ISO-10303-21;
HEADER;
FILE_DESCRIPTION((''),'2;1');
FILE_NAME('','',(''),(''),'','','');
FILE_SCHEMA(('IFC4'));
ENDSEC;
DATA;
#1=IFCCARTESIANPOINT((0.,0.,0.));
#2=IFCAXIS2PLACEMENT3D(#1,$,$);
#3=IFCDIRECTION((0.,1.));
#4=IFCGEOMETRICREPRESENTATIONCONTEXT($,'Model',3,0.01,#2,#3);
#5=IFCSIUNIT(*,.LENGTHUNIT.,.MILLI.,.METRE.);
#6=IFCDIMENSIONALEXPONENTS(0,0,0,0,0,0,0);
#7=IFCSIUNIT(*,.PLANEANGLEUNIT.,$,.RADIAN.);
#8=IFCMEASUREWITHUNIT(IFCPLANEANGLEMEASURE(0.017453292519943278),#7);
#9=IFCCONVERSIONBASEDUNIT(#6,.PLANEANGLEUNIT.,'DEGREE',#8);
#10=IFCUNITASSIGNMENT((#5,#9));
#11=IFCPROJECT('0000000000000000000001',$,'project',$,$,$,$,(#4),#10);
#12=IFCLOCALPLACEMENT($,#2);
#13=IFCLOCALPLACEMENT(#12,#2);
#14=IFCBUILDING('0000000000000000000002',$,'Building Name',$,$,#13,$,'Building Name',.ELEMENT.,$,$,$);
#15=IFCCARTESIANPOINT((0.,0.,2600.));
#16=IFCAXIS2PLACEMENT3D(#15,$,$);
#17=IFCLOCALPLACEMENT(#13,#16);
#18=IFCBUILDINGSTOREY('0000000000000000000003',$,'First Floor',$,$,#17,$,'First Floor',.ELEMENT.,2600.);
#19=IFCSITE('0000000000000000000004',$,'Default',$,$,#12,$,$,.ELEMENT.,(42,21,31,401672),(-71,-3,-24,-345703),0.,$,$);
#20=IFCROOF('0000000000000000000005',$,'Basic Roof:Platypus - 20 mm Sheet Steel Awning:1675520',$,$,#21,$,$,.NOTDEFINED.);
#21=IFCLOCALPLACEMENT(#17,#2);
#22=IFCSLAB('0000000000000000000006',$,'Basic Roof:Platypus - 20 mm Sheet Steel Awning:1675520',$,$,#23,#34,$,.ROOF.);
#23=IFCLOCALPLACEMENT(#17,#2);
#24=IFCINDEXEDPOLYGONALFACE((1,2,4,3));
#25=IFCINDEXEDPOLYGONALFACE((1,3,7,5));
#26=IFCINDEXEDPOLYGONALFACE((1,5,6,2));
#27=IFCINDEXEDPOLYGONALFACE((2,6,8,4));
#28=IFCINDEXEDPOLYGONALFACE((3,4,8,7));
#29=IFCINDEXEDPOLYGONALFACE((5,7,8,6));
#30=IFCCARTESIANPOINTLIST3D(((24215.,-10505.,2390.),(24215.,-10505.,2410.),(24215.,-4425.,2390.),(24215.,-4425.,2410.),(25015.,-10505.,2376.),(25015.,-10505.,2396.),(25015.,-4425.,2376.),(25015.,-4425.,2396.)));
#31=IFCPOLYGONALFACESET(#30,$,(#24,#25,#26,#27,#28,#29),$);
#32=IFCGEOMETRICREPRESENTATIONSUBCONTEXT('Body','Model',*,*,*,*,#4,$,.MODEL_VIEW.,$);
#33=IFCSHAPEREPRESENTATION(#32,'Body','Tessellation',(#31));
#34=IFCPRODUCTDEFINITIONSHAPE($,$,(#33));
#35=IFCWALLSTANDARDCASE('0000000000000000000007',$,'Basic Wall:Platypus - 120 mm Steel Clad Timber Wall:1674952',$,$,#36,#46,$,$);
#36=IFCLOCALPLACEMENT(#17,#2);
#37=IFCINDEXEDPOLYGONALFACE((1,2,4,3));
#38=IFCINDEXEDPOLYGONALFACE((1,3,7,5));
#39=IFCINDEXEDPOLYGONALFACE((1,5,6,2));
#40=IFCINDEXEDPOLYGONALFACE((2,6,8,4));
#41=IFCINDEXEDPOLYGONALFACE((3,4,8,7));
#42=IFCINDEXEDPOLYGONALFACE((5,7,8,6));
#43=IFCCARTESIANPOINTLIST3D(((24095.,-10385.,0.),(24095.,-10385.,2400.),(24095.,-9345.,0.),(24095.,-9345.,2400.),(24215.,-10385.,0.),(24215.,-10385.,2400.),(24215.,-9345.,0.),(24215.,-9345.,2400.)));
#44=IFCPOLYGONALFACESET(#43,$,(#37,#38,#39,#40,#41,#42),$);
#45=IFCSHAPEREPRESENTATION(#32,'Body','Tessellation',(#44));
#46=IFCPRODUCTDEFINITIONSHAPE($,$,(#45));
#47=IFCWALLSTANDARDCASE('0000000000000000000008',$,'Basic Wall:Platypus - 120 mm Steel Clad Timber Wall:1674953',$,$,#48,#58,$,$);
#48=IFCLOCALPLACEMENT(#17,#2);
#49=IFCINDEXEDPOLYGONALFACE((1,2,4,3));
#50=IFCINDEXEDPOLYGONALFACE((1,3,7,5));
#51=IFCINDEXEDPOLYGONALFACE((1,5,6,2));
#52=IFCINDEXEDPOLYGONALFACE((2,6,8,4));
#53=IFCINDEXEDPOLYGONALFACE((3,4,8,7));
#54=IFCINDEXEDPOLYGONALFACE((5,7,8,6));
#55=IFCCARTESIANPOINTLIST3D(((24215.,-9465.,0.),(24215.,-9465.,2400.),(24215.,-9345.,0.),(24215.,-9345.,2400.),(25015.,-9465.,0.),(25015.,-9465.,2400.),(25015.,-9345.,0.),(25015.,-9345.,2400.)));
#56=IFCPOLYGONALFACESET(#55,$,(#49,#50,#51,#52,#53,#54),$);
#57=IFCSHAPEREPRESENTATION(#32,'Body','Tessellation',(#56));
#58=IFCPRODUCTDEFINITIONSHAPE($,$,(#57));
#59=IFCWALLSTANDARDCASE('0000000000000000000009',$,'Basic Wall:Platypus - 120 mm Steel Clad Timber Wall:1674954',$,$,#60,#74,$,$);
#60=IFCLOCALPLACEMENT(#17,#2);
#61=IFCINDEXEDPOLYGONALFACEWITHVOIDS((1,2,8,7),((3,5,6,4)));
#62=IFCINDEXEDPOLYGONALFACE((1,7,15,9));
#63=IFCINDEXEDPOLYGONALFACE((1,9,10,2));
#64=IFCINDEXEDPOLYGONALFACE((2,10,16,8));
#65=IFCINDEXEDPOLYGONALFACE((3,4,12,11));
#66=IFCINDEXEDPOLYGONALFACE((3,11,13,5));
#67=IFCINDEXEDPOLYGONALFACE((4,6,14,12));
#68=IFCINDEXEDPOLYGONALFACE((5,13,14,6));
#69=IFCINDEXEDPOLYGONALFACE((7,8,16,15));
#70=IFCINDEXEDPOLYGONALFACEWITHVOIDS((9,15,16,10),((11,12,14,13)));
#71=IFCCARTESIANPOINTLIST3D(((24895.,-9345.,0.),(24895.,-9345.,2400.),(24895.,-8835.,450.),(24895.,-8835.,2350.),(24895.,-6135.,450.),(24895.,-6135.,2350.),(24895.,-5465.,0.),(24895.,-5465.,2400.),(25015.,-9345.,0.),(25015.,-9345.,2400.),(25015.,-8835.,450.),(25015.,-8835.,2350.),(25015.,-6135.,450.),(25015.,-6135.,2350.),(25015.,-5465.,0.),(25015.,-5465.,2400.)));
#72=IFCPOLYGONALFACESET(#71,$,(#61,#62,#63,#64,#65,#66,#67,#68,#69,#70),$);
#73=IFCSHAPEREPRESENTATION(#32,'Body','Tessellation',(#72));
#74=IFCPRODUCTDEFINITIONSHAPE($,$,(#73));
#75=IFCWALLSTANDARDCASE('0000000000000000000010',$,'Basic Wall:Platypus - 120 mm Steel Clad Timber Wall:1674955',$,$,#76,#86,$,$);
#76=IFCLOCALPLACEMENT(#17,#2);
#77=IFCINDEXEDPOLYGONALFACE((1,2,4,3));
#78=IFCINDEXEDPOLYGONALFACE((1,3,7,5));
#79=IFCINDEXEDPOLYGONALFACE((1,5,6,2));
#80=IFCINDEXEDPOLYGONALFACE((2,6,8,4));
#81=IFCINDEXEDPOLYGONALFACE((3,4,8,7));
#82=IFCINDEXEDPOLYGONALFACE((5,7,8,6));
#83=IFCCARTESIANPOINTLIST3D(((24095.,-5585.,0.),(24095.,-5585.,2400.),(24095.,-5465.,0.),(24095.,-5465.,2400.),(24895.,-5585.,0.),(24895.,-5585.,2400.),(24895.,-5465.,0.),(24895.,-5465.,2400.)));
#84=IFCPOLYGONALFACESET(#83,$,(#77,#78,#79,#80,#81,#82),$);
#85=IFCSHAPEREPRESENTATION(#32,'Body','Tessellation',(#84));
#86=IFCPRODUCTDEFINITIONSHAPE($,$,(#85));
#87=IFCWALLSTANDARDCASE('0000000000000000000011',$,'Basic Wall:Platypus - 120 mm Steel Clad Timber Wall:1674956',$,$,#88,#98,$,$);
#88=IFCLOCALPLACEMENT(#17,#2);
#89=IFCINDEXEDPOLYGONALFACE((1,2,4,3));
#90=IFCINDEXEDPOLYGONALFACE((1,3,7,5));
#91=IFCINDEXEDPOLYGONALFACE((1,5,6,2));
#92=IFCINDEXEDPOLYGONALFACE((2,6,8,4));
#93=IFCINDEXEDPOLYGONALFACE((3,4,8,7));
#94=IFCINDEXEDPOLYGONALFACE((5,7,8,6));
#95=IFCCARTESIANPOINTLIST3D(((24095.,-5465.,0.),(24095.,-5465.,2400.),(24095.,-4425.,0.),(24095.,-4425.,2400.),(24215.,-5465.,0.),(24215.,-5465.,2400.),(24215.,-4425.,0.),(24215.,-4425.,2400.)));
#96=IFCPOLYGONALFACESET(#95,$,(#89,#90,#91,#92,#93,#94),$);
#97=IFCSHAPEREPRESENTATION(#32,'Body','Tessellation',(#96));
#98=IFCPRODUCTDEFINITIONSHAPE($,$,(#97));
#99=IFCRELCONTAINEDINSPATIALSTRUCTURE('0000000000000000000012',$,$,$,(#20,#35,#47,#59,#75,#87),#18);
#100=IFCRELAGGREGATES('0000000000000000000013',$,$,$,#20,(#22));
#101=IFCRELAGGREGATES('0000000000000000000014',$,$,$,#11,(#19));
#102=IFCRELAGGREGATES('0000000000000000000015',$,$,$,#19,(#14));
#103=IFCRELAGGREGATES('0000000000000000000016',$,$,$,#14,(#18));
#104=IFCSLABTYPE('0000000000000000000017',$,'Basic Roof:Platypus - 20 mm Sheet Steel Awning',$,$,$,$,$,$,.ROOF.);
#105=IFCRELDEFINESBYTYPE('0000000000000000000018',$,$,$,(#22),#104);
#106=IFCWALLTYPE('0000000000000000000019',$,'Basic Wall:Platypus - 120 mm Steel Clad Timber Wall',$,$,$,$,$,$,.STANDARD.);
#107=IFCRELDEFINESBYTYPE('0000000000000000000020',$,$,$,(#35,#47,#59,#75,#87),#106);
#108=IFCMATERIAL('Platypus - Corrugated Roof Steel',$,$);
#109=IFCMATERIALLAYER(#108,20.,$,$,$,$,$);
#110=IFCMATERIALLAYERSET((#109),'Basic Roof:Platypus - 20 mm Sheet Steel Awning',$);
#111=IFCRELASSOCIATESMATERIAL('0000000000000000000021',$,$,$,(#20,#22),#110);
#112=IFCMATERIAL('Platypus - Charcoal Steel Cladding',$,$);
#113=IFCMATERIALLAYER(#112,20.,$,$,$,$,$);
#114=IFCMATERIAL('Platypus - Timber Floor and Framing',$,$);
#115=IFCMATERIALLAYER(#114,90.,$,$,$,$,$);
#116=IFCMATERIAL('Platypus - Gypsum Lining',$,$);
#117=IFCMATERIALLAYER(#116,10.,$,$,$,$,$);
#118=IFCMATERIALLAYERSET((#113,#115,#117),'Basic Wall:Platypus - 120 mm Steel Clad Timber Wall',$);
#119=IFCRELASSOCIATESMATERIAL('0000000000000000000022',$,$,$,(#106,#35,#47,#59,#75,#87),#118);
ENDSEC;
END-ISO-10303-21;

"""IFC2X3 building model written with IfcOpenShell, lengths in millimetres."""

from ifc_helpers import new_model, entity, si_unit, converted_unit, direction, frame, frame_2d, origin, place, context, subcontext, project, spatial, rectangle, extrude, material, layer, layer_set, layer_usage, type_object, element, aggregate, save


model = new_model("IFC2X3")

# Units and contexts
model_context = context("Model", 3, precision=0.01, world=origin(), true_north=direction((0.0, 1.0)))
body_context = subcontext(model_context, "Body", "Model", "MODEL_VIEW")
ifc_project = project(units=[si_unit("LENGTHUNIT", "METRE", prefix="MILLI"), converted_unit("PLANEANGLEUNIT", "DEGREE", entity("IfcPlaneAngleMeasure", 0.017453292519943278), si_unit("PLANEANGLEUNIT", "RADIAN"), dimensions=[0, 0, 0, 0, 0, 0, 0])], contexts=[model_context])

# Site, building, storey
site_placement = place(None, origin())
site = spatial("IfcSite", under=ifc_project, at=site_placement, Name="Default", CompositionType="ELEMENT", RefLatitude=(42, 21, 31, 401672), RefLongitude=(-71, -3, -24, -345703), RefElevation=0.0)
building_placement = place(site_placement, origin())
building = spatial("IfcBuilding", under=site, at=building_placement, Name="Building Name", LongName="Building Name", CompositionType="ELEMENT")
storey_placement = place(building_placement, frame((0.0, 0.0, 2600.0)))
storey = spatial("IfcBuildingStorey", under=building, at=storey_placement, Name="First Floor", LongName="First Floor", CompositionType="ELEMENT", Elevation=2600.0)

# Roof, slab
ifc_material_1 = material(Name="Platypus - Corrugated Roof Steel")
ifc_layer_1 = layer(ifc_material_1, 20.0)
ifc_layer_set_1 = layer_set([ifc_layer_1], Name="Basic Roof:Platypus - 20 mm Sheet Steel Awning")
roof_placement = place(storey_placement, frame((24215.0, -10505.0, 2376.0)))
roof = element("IfcRoof", 1, at=roof_placement, inside=storey, material=ifc_layer_set_1, Name="Basic Roof:Platypus - 20 mm Sheet Steel Awning:1675520", ShapeType="NOTDEFINED")
slab_type = type_object("IfcSlabType", Name="Basic Roof:Platypus - 20 mm Sheet Steel Awning", PredefinedType="ROOF")
slab_placement = place(roof_placement, origin())
slab = element("IfcSlab", 2, at=slab_placement, type_object=slab_type, material=ifc_layer_set_1, Name="Basic Roof:Platypus - 20 mm Sheet Steel Awning:1675520", PredefinedType="ROOF", context=body_context, shape_type="SweptSolid", body=[
    extrude(rectangle(XDim=800.1, YDim=6080.0, at=frame_2d((0.0, 0.0), x_axis=(-1.0, 0.0))), frame((400.0, 3040.0, 7.0), z_axis=(0.017451, 0.0, 0.999848), x_axis=(0.999848, 0.0, -0.017451)), (-0.017451, 0.0, 0.999848), 20.0),
])
aggregate(roof, [slab])

# Walls
ifc_material_2 = material(Name="Platypus - Charcoal Steel Cladding")
ifc_layer_2 = layer(ifc_material_2, 20.0)
ifc_material_3 = material(Name="Platypus - Timber Floor and Framing")
ifc_layer_3 = layer(ifc_material_3, 90.0)
ifc_material_4 = material(Name="Platypus - Gypsum Lining")
ifc_layer_4 = layer(ifc_material_4, 10.0)
ifc_layer_set_2 = layer_set([ifc_layer_2, ifc_layer_3, ifc_layer_4], Name="Basic Wall:Platypus - 120 mm Steel Clad Timber Wall")
ifc_layer_usage_1 = layer_usage(ifc_layer_set_2, "AXIS2", "POSITIVE", -60.0)
wall_type = type_object("IfcWallType", Name="Basic Wall:Platypus - 120 mm Steel Clad Timber Wall", PredefinedType="STANDARD", material=ifc_layer_set_2)
wall_1_placement = place(storey_placement, frame((24155.0, -10385.0, 0.0), z_axis=(0.0, 0.0, 1.0), x_axis=(0.0, 1.0, 0.0)))
element("IfcWallStandardCase", 3, at=wall_1_placement, inside=storey, type_object=wall_type, material=ifc_layer_usage_1, Name="Basic Wall:Platypus - 120 mm Steel Clad Timber Wall:1674952", context=body_context, shape_type="SweptSolid", body=[
    extrude(rectangle(XDim=1040.0, YDim=120.0, at=frame_2d((520.0, 0.0), x_axis=(-1.0, 0.0))), origin(), (0.0, 0.0, 1.0), 2400.0),
])
ifc_layer_usage_2 = layer_usage(ifc_layer_set_2, "AXIS2", "POSITIVE", -60.0)
wall_2_placement = place(storey_placement, frame((24215.0, -9405.0, 0.0)))
element("IfcWallStandardCase", 4, at=wall_2_placement, inside=storey, type_object=wall_type, material=ifc_layer_usage_2, Name="Basic Wall:Platypus - 120 mm Steel Clad Timber Wall:1674953", context=body_context, shape_type="SweptSolid", body=[
    extrude(rectangle(XDim=800.0, YDim=120.0, at=frame_2d((400.0, 0.0), x_axis=(-1.0, 0.0))), origin(), (0.0, 0.0, 1.0), 2400.0),
])

# Wall, opening
ifc_layer_usage_3 = layer_usage(ifc_layer_set_2, "AXIS2", "POSITIVE", -60.0)
wall_3_placement = place(storey_placement, frame((24955.0, -9345.0, 0.0), z_axis=(0.0, 0.0, 1.0), x_axis=(0.0, 1.0, 0.0)))
wall_3 = element("IfcWallStandardCase", 5, at=wall_3_placement, inside=storey, type_object=wall_type, material=ifc_layer_usage_3, Name="Basic Wall:Platypus - 120 mm Steel Clad Timber Wall:1674954", context=body_context, shape_type="SweptSolid", body=[
    extrude(rectangle(XDim=3880.0, YDim=120.0, at=frame_2d((1940.0, 0.0), x_axis=(-1.0, 0.0))), origin(), (0.0, 0.0, 1.0), 2400.0),
])
opening_1_placement = place(wall_3_placement, frame((510.0, -60.0, 450.0)))
element("IfcOpeningElement", 6, at=opening_1_placement, cuts=wall_3, ObjectType="Opening", context=body_context, shape_type="SweptSolid", body=[
    extrude(rectangle(XDim=1900.0, YDim=2700.0, at=frame_2d((950.0, 1350.0), x_axis=(-1.0, 0.0))), frame((0.0, 0.0, 0.0), z_axis=(0.0, 1.0, 0.0), x_axis=(0.0, 0.0, 1.0)), (0.0, 0.0, 1.0), 120.0),
])

# Walls
ifc_layer_usage_4 = layer_usage(ifc_layer_set_2, "AXIS2", "POSITIVE", -60.0)
wall_4_placement = place(storey_placement, frame((24895.0, -5525.0, 0.0), z_axis=(0.0, 0.0, 1.0), x_axis=(-1.0, 0.0, 0.0)))
element("IfcWallStandardCase", 7, at=wall_4_placement, inside=storey, type_object=wall_type, material=ifc_layer_usage_4, Name="Basic Wall:Platypus - 120 mm Steel Clad Timber Wall:1674955", context=body_context, shape_type="SweptSolid", body=[
    extrude(rectangle(XDim=800.0, YDim=120.0, at=frame_2d((400.0, 0.0), x_axis=(-1.0, 0.0))), origin(), (0.0, 0.0, 1.0), 2400.0),
])
ifc_layer_usage_5 = layer_usage(ifc_layer_set_2, "AXIS2", "POSITIVE", -60.0)
wall_5_placement = place(storey_placement, frame((24155.0, -5465.0, 0.0), z_axis=(0.0, 0.0, 1.0), x_axis=(0.0, 1.0, 0.0)))
element("IfcWallStandardCase", 8, at=wall_5_placement, inside=storey, type_object=wall_type, material=ifc_layer_usage_5, Name="Basic Wall:Platypus - 120 mm Steel Clad Timber Wall:1674956", context=body_context, shape_type="SweptSolid", body=[
    extrude(rectangle(XDim=1040.0, YDim=120.0, at=frame_2d((520.0, 0.0), x_axis=(-1.0, 0.0))), origin(), (0.0, 0.0, 1.0), 2400.0),
])

save(model, "model.ifc")
